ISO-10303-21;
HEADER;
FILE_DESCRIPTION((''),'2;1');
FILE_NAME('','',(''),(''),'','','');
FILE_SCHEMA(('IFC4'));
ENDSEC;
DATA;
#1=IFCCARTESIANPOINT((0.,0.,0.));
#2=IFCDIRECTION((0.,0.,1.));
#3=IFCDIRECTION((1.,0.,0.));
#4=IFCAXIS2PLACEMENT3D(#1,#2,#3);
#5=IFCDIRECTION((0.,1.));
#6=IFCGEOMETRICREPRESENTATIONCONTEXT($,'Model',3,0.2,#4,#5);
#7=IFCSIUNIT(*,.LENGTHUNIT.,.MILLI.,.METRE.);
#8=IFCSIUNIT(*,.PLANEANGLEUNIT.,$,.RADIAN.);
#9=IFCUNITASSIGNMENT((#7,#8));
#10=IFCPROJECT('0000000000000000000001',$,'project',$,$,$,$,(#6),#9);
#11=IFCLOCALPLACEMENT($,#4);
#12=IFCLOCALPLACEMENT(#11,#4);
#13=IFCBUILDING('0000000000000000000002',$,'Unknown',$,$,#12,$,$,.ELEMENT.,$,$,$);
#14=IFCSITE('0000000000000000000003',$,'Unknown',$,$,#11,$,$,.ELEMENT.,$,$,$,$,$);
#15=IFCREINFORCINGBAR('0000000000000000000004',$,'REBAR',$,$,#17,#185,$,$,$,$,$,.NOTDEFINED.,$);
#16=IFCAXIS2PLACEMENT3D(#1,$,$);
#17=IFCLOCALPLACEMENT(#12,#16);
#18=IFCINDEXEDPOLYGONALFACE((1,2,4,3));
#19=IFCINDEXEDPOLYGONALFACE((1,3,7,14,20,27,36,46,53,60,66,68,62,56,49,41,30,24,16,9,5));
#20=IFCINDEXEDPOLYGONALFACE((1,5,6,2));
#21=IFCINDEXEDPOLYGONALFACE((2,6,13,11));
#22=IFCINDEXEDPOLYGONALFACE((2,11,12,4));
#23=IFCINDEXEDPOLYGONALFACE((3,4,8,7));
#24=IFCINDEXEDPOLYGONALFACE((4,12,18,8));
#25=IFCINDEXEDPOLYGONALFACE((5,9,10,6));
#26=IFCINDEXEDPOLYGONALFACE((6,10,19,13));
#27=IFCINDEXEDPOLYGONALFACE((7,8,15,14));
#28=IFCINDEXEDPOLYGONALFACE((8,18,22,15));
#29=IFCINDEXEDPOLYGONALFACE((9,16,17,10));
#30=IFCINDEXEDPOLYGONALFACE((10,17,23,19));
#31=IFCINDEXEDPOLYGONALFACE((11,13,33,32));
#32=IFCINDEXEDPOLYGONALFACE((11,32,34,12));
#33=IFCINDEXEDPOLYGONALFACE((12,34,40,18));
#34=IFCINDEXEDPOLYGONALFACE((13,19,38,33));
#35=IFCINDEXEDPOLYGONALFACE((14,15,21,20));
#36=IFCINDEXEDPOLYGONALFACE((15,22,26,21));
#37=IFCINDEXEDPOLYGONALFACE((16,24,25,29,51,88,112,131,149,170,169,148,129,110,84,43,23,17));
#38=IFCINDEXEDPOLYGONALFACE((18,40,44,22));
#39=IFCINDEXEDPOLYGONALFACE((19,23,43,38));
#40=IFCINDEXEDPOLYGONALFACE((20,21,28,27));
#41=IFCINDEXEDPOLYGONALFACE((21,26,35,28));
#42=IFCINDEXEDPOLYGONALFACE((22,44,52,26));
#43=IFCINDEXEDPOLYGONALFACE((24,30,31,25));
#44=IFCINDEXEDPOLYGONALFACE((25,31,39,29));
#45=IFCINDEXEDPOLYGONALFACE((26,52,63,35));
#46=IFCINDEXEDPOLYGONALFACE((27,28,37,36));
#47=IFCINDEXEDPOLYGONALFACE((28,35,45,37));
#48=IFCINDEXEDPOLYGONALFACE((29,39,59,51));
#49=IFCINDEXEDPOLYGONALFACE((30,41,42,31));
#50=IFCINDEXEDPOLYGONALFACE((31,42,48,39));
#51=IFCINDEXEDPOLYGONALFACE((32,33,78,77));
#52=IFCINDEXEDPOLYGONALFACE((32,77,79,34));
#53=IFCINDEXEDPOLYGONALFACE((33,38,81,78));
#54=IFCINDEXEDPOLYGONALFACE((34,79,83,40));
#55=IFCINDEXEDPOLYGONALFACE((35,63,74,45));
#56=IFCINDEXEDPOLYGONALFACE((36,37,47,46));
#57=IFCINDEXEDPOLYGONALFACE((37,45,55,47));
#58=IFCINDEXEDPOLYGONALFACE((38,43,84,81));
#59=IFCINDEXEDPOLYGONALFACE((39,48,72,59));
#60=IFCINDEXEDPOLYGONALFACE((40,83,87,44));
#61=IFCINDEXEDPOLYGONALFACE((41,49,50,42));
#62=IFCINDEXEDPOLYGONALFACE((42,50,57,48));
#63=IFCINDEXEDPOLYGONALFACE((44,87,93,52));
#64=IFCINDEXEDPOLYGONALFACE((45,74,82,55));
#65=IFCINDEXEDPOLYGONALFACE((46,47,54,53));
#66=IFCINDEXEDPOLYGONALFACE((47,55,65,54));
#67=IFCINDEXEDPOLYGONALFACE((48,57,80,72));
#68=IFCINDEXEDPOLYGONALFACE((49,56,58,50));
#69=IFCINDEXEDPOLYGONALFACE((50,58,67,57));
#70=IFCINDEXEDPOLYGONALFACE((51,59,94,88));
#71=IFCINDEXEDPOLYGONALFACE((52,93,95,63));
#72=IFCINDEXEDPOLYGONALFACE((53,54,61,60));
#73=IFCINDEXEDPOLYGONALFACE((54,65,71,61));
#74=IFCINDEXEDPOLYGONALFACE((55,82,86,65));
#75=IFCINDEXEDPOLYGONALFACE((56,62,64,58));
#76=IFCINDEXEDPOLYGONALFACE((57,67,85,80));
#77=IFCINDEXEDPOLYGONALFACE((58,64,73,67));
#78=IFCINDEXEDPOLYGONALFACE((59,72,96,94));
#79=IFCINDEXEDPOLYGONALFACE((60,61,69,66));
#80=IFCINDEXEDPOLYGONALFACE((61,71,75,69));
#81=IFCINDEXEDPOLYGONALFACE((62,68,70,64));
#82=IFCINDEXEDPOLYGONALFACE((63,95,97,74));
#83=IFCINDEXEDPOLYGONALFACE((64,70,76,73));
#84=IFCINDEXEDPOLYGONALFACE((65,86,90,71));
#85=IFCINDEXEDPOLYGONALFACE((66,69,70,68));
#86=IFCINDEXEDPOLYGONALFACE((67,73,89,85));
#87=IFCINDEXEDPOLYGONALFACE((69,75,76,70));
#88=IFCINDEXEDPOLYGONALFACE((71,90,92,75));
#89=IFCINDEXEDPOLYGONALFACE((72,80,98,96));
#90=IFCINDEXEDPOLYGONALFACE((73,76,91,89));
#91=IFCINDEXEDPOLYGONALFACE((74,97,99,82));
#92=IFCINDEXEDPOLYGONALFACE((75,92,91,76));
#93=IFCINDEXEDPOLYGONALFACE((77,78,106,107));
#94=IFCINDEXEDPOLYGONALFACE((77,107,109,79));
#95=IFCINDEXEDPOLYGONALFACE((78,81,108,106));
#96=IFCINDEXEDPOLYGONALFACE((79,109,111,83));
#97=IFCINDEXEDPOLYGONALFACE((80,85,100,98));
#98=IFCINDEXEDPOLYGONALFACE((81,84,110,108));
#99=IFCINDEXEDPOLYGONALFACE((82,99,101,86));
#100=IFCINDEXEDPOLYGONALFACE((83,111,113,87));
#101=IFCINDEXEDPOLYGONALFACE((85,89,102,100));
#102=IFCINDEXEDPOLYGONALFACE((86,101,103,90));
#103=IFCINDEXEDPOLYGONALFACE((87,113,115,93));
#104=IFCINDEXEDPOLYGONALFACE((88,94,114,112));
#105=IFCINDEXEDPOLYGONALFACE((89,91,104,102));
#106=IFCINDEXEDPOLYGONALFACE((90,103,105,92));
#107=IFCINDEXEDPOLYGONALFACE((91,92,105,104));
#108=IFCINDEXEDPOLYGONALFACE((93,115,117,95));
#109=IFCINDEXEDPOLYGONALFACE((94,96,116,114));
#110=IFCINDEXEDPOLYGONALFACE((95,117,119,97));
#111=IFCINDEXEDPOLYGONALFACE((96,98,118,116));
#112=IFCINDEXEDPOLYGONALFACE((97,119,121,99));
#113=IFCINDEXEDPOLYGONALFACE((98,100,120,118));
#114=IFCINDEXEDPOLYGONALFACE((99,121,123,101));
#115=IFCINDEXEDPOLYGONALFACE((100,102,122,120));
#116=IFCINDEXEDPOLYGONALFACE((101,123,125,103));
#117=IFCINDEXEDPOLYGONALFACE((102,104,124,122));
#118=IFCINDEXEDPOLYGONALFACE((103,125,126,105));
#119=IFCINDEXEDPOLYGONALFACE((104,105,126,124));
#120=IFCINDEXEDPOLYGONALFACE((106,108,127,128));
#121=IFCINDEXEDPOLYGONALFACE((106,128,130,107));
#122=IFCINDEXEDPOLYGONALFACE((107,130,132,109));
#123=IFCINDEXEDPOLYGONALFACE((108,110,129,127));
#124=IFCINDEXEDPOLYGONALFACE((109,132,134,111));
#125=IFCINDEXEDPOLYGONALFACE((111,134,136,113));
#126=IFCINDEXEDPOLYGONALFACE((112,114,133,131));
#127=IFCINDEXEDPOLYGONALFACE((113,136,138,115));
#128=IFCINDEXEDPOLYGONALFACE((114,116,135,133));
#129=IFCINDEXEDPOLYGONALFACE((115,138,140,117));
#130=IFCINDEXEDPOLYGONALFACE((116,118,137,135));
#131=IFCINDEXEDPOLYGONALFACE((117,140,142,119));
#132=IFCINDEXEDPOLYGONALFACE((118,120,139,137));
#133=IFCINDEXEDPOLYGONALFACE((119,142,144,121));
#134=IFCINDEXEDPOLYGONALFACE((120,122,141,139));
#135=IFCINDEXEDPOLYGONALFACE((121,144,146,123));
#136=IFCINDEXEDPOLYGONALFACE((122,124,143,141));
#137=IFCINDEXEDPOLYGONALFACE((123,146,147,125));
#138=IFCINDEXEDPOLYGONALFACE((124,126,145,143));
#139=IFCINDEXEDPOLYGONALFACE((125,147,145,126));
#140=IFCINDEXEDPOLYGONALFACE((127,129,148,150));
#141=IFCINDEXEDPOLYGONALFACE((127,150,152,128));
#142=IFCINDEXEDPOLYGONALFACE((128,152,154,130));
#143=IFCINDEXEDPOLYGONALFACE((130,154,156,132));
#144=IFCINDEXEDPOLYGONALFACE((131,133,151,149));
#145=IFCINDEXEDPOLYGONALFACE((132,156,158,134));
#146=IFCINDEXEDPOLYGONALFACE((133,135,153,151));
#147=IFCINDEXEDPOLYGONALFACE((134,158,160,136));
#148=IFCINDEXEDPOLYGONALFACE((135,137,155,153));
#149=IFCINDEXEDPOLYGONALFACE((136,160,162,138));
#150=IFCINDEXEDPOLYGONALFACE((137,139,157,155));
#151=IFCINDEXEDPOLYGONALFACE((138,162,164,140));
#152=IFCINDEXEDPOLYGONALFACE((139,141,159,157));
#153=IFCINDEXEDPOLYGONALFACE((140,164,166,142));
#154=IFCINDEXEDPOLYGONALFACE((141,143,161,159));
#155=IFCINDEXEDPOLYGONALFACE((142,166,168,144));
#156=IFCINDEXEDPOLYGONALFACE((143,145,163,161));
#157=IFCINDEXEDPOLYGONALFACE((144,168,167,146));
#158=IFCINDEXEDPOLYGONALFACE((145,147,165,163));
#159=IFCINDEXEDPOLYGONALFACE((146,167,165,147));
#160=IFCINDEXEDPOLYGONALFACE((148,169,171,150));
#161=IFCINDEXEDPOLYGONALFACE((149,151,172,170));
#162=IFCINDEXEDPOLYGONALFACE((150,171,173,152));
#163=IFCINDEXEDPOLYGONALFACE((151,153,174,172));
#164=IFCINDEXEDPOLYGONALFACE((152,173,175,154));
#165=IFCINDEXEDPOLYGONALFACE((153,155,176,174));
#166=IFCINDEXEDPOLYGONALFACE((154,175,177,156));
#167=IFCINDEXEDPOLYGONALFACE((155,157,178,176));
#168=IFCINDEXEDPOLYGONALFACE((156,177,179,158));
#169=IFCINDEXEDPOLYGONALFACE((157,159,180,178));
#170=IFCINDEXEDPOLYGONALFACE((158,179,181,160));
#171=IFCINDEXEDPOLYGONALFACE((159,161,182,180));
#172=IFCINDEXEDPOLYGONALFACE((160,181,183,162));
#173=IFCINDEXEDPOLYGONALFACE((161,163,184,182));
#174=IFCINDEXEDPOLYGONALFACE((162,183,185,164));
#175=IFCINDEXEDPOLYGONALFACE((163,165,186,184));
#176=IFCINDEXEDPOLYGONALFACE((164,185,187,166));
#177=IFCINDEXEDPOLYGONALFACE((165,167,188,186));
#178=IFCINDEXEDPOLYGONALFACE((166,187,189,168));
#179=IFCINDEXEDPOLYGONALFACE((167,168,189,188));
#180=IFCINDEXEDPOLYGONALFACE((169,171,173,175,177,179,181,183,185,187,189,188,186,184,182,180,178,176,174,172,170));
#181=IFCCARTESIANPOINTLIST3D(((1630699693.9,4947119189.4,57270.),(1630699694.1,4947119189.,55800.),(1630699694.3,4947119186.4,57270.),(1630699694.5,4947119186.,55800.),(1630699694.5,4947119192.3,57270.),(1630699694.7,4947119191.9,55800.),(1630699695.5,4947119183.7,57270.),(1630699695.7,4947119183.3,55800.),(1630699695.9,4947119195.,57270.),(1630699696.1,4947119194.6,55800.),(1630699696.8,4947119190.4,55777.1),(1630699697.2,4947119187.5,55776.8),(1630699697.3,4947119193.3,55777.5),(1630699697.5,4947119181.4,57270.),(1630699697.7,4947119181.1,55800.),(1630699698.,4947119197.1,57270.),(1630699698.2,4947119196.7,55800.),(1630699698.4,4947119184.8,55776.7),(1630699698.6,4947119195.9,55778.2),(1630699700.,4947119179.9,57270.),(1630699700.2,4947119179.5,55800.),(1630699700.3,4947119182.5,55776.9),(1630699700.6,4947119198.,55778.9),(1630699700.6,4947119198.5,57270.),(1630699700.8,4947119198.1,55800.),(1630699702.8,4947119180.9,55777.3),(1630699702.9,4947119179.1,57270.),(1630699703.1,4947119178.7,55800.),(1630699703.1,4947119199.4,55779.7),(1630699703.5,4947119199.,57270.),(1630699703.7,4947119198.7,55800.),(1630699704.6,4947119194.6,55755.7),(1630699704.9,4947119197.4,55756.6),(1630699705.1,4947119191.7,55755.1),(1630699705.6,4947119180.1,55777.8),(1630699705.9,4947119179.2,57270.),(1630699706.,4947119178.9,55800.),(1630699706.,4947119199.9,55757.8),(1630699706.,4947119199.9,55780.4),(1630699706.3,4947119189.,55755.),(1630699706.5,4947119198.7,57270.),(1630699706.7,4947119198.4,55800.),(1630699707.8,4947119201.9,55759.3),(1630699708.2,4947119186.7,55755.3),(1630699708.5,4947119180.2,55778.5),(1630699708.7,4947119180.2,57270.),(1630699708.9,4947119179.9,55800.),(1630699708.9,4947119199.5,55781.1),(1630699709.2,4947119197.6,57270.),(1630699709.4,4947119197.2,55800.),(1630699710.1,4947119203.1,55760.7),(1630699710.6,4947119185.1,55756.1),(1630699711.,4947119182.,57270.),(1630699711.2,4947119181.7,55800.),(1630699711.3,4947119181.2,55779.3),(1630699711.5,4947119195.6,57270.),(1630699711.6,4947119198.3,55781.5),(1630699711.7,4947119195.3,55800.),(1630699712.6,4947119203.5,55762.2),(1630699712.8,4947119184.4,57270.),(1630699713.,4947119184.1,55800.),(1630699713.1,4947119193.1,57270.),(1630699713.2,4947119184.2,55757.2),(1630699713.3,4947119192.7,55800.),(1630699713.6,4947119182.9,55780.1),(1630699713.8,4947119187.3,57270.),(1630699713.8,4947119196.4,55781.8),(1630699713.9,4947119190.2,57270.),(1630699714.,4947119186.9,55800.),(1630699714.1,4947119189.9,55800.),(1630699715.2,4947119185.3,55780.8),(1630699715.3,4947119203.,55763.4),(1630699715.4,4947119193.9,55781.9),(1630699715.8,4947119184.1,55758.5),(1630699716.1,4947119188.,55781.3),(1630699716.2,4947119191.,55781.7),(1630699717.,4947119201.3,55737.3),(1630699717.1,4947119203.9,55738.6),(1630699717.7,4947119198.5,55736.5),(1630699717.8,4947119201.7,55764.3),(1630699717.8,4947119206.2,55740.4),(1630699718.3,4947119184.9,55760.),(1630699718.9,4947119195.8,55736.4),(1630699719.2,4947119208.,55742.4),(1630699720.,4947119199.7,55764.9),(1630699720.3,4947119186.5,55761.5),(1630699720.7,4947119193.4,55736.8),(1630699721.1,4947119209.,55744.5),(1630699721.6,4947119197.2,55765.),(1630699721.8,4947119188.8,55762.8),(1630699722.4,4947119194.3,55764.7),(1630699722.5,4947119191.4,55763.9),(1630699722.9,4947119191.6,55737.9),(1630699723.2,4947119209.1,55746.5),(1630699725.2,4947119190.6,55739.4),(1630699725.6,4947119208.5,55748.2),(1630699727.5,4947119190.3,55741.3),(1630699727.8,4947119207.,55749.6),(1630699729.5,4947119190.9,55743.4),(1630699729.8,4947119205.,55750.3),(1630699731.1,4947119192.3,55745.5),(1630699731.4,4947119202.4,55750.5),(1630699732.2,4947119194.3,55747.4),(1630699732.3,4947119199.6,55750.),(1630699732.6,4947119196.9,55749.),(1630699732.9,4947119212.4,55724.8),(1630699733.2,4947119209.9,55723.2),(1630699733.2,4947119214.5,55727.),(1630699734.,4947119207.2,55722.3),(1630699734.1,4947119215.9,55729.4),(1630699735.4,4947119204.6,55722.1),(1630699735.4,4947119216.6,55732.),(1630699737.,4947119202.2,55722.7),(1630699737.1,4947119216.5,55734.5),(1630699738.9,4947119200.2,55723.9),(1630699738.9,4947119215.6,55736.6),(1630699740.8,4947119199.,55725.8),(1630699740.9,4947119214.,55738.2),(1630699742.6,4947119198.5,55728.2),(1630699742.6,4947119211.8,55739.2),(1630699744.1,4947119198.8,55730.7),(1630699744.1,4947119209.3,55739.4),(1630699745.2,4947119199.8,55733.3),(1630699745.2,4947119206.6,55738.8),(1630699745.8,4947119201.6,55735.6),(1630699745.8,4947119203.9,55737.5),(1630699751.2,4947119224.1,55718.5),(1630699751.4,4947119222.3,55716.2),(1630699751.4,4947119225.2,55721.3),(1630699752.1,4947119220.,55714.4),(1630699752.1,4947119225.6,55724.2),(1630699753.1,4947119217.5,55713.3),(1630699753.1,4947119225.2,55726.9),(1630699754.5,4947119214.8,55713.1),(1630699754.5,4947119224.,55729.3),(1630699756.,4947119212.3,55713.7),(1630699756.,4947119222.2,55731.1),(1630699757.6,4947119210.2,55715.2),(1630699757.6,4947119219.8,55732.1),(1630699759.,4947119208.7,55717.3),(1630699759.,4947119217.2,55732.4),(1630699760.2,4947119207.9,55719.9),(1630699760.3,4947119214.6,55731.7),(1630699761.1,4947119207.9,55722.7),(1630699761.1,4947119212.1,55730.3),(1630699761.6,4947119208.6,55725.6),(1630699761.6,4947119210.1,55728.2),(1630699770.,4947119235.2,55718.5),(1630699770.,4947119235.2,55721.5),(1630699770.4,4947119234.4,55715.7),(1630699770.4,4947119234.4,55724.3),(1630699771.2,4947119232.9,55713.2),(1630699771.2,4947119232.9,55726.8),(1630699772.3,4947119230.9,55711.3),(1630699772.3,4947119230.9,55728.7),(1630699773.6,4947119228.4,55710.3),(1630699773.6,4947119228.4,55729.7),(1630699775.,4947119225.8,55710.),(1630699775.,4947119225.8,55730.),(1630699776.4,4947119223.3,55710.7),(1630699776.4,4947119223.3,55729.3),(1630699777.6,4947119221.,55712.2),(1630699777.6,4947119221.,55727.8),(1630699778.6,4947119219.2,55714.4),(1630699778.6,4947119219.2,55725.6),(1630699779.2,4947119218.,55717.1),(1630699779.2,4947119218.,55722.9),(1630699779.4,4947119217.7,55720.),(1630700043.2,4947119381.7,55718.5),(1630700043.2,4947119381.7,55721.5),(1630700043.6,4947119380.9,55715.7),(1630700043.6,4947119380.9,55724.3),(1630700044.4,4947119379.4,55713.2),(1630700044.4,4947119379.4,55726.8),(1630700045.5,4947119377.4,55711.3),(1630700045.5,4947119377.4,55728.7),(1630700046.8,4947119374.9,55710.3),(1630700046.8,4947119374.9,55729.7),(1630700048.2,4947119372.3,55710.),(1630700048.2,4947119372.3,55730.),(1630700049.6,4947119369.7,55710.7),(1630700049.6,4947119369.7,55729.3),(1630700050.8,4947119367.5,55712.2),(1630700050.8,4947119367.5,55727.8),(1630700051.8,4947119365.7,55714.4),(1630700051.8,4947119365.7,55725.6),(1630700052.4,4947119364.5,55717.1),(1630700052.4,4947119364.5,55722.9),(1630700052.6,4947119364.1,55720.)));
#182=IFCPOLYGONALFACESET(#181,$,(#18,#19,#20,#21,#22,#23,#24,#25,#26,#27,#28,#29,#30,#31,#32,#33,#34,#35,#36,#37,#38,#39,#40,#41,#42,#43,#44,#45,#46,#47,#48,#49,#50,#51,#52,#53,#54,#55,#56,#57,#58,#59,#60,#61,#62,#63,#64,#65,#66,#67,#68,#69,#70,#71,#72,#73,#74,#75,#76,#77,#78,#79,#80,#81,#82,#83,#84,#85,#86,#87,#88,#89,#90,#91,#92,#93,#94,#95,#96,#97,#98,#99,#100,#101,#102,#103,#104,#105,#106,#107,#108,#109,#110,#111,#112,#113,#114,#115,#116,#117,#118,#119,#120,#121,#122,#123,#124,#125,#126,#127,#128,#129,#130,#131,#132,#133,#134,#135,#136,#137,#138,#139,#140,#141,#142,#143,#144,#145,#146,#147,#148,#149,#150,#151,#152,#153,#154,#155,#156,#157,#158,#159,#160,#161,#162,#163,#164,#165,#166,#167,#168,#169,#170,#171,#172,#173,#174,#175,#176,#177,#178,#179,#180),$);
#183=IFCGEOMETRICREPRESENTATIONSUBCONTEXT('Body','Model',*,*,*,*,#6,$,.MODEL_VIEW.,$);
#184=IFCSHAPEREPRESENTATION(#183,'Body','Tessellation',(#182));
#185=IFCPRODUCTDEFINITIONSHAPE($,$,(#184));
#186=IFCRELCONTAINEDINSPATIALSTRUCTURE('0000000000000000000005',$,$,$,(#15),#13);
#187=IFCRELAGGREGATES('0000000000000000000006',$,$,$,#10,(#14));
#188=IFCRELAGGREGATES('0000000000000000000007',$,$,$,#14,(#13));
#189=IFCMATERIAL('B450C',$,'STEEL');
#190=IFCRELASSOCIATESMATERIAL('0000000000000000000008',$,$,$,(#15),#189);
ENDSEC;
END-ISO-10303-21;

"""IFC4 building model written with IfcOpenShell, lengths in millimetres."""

from ifc_helpers import new_model, entity, si_unit, direction, frame, origin_with_axes, place, context, subcontext, project, spatial, material, element, save


model = new_model("IFC4")

# Units and contexts
model_context = context("Model", 3, precision=0.2, world=origin_with_axes(), true_north=direction((0.0, 1.0)))
body_context = subcontext(model_context, "Body", "Model", "MODEL_VIEW")
ifc_project = project(units=[si_unit("LENGTHUNIT", "METRE", prefix="MILLI"), si_unit("PLANEANGLEUNIT", "RADIAN")], contexts=[model_context])

# Site, building
site_placement = place(None, origin_with_axes())
site = spatial("IfcSite", under=ifc_project, at=site_placement, Name="Unknown", CompositionType="ELEMENT")
building_placement = place(site_placement, origin_with_axes())
building = spatial("IfcBuilding", under=site, at=building_placement, Name="Unknown", CompositionType="ELEMENT")

# Reinforcing bar
ifc_material = material(Name="B450C", Category="STEEL")
reinforcing_bar_1_placement = place(building_placement, frame((1630699636.4, 4947119209.1, 55670.0), z_axis=(0.472812, -0.881163, 0.0), x_axis=(0.0, 0.0, 1.0)))
element("IfcReinforcingBar", 1, at=reinforcing_bar_1_placement, inside=building, material=ifc_material, Name="REBAR", PredefinedType="NOTDEFINED", context=body_context, shape_type="AdvancedSweptSolid", body=[
    entity("IfcSweptDiskSolid", entity("IfcIndexedPolyCurve", entity("IfcCartesianPointList3D", [[50.0, -440.0, 50.1], [50.0, -130.0, 50.0], [73.4, -73.4, 50.0], [130.0, -50.0, 50.0], [1600.0, -50.0, 49.6]]), [entity("IfcLineIndex", [1, 2]), entity("IfcArcIndex", [2, 3, 4]), entity("IfcLineIndex", [4, 5])]), 10.0),
])

save(model, "model.ifc")
